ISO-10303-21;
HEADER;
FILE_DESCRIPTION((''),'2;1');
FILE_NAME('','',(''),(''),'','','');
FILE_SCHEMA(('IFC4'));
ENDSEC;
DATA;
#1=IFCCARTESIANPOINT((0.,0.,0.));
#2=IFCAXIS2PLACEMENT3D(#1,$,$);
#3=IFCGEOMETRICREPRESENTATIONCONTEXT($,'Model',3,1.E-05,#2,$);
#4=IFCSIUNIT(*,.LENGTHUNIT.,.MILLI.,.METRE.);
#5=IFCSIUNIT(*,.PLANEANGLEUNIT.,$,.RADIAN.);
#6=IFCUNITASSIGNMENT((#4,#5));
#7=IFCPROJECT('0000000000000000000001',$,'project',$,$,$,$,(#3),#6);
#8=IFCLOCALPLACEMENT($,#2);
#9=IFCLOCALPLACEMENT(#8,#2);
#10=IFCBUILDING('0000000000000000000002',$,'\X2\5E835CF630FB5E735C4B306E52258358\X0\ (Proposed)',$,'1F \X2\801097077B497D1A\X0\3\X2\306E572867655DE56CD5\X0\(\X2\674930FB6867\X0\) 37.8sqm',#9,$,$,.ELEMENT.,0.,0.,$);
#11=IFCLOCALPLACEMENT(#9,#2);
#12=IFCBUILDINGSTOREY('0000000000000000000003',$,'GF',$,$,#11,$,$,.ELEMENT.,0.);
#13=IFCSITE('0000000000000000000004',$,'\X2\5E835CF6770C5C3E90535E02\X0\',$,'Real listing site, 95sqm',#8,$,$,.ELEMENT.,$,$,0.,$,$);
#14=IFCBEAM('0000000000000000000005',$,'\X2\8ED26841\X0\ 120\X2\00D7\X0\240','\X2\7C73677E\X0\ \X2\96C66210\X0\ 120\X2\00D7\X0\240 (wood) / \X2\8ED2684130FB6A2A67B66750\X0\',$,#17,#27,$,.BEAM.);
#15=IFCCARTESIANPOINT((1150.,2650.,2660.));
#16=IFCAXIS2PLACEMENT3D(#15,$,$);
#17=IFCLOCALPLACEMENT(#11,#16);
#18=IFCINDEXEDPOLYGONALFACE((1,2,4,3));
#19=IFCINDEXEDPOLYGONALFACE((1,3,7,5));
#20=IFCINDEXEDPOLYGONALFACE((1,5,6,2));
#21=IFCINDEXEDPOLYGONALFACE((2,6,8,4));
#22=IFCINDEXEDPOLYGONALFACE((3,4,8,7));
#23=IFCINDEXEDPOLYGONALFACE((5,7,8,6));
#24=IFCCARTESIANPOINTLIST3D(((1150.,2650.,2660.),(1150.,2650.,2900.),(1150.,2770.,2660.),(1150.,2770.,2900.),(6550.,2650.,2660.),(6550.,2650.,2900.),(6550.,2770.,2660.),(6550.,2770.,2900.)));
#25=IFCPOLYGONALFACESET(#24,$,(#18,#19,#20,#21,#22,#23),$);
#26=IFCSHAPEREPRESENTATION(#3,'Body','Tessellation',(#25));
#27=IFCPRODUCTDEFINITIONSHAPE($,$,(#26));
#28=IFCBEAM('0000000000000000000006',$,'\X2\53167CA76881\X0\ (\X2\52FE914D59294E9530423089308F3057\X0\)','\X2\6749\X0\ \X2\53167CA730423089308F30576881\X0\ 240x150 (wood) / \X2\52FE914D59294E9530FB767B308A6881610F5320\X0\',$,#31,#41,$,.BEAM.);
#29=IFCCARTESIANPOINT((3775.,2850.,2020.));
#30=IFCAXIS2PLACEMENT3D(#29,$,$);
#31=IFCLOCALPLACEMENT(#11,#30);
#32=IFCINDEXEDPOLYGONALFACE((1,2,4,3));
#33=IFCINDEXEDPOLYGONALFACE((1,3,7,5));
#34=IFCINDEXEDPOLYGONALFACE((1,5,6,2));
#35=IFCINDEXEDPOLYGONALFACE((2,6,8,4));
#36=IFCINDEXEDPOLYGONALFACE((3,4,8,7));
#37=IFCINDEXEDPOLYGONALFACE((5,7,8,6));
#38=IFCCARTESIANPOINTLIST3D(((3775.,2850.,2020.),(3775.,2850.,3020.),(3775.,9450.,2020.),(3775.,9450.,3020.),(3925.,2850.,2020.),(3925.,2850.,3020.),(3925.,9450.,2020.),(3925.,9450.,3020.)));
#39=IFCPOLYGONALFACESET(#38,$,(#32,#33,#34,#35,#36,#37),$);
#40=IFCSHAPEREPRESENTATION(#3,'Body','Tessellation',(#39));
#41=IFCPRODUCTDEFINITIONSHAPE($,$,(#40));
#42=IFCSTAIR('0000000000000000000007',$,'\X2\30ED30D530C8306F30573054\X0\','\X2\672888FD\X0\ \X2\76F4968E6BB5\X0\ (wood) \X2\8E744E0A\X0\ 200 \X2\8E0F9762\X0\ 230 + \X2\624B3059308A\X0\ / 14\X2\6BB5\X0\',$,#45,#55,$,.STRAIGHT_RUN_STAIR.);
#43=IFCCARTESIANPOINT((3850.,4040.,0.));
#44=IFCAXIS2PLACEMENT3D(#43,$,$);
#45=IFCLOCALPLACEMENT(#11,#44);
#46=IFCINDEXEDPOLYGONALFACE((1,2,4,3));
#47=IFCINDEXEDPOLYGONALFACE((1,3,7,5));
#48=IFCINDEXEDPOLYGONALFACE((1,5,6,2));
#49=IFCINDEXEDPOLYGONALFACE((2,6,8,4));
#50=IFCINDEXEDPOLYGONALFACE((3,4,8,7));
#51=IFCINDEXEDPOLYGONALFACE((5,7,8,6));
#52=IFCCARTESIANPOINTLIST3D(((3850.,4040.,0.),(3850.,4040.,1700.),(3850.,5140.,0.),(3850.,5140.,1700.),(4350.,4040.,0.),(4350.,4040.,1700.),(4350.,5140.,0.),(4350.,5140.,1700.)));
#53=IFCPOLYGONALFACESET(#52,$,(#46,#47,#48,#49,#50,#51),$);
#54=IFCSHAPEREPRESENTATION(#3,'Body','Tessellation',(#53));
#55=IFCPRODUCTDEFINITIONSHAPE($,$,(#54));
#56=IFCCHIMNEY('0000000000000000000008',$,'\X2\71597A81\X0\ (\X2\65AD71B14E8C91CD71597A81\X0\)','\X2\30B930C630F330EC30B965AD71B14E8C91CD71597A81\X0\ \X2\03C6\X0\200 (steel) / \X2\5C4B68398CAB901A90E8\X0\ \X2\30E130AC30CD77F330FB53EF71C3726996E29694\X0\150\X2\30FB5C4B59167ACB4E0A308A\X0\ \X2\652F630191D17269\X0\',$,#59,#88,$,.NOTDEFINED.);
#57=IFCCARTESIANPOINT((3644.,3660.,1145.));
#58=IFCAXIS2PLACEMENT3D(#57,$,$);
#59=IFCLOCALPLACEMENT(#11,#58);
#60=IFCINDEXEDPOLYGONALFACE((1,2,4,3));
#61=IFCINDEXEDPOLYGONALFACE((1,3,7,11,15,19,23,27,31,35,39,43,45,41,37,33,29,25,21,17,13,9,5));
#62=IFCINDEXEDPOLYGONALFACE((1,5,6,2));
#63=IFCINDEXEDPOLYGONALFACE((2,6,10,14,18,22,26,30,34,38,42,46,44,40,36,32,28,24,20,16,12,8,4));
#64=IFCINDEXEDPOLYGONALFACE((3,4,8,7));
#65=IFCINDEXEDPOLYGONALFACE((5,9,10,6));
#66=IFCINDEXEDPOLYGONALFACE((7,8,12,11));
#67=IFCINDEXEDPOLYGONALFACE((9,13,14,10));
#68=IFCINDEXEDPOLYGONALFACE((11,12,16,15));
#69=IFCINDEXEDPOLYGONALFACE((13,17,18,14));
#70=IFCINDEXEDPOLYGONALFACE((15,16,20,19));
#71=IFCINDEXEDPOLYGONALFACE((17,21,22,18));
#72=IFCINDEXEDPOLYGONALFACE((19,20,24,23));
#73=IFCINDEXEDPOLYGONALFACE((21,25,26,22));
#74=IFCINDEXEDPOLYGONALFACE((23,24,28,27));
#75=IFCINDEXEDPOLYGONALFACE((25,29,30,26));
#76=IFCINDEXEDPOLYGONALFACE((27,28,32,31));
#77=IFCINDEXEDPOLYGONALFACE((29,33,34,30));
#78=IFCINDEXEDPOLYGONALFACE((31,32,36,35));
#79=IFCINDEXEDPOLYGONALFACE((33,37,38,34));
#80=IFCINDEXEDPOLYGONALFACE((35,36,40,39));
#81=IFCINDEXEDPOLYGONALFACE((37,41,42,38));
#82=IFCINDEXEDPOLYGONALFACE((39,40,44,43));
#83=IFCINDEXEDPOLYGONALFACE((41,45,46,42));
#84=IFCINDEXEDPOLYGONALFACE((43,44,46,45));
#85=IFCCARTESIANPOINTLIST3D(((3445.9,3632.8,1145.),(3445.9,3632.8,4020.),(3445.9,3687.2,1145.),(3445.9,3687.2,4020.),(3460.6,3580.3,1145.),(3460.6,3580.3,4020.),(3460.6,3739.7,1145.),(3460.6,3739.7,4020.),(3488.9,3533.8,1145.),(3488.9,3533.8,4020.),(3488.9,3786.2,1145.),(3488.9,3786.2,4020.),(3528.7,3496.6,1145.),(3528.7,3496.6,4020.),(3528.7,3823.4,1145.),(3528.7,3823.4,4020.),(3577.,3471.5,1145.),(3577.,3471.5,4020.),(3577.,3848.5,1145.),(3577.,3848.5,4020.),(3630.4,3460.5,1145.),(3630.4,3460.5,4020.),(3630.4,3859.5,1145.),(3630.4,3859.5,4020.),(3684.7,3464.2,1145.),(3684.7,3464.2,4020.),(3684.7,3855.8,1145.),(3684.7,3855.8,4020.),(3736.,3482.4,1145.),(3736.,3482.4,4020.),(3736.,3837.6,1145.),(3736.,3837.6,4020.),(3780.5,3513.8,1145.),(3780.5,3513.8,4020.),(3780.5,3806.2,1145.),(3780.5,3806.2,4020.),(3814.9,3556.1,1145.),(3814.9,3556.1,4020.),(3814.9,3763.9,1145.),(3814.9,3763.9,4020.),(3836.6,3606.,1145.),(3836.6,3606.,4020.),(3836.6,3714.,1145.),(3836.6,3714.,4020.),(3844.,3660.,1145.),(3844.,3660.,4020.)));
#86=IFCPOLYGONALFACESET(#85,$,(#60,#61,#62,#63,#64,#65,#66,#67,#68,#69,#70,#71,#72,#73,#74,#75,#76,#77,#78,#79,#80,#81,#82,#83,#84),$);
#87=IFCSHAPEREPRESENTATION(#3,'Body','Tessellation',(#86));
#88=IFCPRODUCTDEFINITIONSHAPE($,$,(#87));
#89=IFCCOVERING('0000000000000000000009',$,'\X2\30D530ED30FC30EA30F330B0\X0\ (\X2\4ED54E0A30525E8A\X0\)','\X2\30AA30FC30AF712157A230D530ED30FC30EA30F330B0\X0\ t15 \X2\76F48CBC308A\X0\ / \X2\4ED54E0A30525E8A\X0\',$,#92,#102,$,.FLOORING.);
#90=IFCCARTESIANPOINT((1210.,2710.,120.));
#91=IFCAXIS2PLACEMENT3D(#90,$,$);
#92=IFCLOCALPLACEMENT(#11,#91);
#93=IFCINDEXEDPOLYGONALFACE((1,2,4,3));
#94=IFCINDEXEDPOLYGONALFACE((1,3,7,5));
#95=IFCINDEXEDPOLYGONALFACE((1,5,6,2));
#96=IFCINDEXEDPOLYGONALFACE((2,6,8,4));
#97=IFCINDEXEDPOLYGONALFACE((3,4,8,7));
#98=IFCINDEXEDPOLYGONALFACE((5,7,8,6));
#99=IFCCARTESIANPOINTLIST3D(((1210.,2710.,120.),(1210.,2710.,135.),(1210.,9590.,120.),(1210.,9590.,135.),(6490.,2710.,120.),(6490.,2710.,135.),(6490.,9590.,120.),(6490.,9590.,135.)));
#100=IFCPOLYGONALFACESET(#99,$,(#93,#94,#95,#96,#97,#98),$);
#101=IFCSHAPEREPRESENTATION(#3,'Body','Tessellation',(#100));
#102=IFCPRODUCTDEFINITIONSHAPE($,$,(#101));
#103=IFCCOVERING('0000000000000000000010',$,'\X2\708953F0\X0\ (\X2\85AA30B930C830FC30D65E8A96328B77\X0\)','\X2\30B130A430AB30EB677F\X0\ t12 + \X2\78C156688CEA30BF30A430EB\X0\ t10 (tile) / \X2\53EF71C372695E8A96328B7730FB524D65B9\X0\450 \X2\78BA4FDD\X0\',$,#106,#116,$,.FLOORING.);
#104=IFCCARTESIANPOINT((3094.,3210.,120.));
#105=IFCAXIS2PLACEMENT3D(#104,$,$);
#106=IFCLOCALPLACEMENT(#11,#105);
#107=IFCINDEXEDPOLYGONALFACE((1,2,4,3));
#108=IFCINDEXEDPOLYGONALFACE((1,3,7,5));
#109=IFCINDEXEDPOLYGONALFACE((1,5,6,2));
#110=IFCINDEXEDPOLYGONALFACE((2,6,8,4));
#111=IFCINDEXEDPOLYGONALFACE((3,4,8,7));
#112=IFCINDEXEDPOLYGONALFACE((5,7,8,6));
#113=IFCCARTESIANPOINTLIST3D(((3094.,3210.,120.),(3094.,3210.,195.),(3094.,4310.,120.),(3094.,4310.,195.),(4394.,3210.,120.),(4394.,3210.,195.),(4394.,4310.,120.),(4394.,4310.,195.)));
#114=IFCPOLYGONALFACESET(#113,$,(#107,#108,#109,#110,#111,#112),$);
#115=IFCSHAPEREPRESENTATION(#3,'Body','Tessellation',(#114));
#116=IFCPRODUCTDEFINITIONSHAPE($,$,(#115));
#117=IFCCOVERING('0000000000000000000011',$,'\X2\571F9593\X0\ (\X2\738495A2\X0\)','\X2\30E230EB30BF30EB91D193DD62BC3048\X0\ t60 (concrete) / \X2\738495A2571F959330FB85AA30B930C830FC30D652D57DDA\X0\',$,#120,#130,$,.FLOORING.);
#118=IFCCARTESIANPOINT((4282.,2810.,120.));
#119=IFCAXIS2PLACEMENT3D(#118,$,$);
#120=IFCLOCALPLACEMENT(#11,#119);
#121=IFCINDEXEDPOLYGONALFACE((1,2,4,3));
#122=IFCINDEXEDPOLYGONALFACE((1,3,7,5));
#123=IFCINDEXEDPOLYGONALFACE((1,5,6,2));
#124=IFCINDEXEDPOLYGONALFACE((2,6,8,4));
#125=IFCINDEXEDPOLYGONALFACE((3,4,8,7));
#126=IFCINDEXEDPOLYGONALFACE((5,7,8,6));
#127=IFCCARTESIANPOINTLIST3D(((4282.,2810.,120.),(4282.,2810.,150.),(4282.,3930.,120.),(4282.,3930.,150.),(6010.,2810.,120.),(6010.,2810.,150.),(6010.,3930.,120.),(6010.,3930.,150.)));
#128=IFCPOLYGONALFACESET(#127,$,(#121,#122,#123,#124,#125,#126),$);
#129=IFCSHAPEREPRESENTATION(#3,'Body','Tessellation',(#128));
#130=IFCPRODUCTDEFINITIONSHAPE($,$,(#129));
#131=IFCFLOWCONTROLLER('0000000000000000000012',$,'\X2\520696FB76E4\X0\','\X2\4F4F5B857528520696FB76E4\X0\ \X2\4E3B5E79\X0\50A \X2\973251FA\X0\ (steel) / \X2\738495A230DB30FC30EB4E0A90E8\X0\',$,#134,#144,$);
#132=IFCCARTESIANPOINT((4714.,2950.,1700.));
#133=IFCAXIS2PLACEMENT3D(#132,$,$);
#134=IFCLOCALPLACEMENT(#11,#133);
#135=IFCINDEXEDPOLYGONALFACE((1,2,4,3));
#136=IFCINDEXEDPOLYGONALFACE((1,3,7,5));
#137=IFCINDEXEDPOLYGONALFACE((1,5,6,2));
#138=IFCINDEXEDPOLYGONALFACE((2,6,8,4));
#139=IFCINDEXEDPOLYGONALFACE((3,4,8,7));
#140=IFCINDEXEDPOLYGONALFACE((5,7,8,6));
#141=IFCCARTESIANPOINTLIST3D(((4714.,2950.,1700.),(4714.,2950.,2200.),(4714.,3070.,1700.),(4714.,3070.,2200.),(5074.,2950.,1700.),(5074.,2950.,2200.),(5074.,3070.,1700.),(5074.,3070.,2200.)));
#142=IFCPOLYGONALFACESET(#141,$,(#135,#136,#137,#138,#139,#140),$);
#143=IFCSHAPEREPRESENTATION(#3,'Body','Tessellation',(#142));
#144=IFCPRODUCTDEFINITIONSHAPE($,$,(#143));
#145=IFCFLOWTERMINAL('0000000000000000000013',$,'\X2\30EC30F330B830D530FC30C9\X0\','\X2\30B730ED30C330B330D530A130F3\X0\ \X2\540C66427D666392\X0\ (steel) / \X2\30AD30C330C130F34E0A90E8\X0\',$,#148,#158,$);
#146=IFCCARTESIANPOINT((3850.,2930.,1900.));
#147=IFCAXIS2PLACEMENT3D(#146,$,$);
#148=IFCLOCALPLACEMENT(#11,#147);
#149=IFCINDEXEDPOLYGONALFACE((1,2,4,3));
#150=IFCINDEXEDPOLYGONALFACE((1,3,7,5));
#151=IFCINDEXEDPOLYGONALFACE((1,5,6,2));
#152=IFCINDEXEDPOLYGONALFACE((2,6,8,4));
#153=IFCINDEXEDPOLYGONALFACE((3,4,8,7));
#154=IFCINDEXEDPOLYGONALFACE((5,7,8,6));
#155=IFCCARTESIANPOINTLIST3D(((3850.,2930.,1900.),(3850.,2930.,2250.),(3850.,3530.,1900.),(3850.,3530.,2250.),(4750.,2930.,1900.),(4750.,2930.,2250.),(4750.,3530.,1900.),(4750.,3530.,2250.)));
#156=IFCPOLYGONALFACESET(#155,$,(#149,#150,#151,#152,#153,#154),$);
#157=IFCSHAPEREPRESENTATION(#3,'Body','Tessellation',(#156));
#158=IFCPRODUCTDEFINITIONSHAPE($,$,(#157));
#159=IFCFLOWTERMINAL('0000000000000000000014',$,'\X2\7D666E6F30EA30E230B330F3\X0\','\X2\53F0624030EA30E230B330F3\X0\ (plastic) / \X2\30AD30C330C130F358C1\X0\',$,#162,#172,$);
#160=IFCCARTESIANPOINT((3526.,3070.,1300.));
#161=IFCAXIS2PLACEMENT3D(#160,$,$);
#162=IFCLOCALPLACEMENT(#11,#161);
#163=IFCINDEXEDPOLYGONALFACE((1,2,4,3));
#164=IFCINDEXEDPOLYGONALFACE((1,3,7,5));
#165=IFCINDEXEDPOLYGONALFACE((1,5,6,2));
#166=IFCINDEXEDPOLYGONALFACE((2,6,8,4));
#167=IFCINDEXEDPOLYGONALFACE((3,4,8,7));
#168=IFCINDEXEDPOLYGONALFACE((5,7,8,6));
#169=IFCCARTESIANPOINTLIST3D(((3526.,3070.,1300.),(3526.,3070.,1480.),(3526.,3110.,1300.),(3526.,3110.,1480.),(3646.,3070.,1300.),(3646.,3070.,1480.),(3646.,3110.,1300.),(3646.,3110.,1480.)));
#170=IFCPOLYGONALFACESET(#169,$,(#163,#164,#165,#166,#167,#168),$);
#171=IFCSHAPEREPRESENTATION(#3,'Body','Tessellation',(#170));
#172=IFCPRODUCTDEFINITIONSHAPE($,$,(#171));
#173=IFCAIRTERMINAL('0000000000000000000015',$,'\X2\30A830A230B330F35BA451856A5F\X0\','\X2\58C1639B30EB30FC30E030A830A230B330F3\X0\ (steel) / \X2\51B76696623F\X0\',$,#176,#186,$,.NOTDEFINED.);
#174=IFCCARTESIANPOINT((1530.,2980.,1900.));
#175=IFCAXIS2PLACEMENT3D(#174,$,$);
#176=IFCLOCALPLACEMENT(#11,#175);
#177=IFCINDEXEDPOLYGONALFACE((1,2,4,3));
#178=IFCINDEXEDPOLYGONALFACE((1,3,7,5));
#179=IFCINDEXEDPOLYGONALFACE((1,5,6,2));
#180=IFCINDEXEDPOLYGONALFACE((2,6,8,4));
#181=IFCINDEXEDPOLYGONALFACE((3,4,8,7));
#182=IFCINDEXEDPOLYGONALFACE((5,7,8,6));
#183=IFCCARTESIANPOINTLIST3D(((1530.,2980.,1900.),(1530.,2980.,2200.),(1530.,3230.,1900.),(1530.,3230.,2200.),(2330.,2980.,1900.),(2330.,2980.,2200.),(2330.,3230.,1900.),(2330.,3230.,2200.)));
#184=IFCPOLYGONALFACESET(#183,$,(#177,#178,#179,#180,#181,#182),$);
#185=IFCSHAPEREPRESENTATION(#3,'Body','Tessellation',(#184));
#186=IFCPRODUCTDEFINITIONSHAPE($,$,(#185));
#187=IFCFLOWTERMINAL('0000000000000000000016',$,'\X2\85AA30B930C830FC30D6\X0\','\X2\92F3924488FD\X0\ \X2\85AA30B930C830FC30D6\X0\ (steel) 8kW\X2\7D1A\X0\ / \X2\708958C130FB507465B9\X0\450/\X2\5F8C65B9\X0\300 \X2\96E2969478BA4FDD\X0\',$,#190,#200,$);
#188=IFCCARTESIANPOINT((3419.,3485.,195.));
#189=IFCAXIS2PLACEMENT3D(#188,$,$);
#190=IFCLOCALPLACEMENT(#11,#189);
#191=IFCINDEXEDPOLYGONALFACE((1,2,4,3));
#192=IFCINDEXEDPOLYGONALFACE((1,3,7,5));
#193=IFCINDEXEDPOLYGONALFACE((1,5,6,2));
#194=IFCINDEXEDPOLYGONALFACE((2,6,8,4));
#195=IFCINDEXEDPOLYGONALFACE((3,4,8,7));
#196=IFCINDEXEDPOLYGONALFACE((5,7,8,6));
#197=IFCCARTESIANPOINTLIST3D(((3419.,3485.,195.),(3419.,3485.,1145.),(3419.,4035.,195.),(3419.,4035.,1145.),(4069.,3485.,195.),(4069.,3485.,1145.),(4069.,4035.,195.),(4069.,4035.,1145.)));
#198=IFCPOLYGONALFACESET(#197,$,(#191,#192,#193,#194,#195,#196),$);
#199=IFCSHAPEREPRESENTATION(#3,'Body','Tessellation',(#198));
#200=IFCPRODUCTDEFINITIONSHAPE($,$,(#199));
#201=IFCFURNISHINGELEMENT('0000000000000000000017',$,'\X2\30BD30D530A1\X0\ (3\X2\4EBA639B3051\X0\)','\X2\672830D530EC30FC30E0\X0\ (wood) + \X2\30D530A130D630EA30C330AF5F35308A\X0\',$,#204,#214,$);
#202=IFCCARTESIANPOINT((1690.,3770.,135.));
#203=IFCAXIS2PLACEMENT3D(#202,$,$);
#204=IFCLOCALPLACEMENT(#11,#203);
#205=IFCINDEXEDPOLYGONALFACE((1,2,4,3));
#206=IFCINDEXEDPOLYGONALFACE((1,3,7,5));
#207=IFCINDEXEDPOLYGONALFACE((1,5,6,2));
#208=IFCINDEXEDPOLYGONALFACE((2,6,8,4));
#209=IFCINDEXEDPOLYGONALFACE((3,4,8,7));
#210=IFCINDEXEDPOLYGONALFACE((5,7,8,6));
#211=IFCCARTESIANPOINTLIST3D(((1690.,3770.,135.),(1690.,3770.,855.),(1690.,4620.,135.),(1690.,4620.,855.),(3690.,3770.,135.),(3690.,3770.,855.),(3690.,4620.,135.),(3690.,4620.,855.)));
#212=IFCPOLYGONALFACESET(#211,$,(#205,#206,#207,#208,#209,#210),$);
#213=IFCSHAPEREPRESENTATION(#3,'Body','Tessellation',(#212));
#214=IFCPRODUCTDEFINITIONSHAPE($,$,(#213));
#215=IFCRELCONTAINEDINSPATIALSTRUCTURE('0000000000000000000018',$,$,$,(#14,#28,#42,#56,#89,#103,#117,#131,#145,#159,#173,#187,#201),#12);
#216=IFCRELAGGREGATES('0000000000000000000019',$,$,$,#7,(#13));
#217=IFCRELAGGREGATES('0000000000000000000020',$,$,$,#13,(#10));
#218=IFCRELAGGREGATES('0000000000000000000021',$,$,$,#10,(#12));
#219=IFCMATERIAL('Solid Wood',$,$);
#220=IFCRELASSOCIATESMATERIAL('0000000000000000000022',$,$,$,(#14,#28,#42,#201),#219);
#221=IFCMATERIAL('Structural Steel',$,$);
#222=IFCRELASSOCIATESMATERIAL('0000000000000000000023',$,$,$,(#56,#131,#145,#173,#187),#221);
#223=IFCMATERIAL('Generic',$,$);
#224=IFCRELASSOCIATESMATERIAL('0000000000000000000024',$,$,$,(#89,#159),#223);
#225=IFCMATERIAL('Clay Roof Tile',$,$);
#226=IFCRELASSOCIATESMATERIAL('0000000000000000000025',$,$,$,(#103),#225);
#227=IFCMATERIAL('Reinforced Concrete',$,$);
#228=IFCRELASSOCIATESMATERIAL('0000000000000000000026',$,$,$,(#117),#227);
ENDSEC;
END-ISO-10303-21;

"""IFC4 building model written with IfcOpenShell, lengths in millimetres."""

from ifc_helpers import new_model, si_unit, frame, frame_2d, origin, origin_2d, place, context, project, spatial, rectangle, circle, extrude, material, element, save


model = new_model("IFC4")

# Units and contexts
model_context = context("Model", 3, precision=1e-05, world=origin())
ifc_project = project(units=[si_unit("LENGTHUNIT", "METRE", prefix="MILLI"), si_unit("PLANEANGLEUNIT", "RADIAN")], contexts=[model_context])

# Site, building, storey
site_placement = place(None, origin())
site = spatial("IfcSite", under=ifc_project, at=site_placement, Name="広島県尾道市", ObjectType="Real listing site, 95sqm", CompositionType="ELEMENT", RefElevation=0.0)
building_placement = place(site_placement, origin())
building = spatial("IfcBuilding", under=site, at=building_placement, Name="広島・平屋の別荘 (Proposed)", ObjectType="1F 耐震等級3の在来工法(杉・桧) 37.8sqm", CompositionType="ELEMENT", ElevationOfRefHeight=0.0, ElevationOfTerrain=0.0)
storey_placement = place(building_placement, origin())
storey = spatial("IfcBuildingStorey", under=building, at=storey_placement, Name="GF", CompositionType="ELEMENT", Elevation=0.0)

# Beams
ifc_material_1 = material(Name="Solid Wood")
beam_1_placement = place(storey_placement, frame((1150.0, 2650.0, 2660.0)))
element("IfcBeam", 1, at=beam_1_placement, inside=storey, material=ifc_material_1, Name="軒桁 120×240", Description="米松 集成 120×240 (wood) / 軒桁・横架材", PredefinedType="BEAM", context=model_context, shape_type="SweptSolid", body=[
    extrude(rectangle(XDim=5400.0, YDim=120.0, at=frame_2d((2700.0, 60.0))), frame((1150.0, 2650.0, 2660.0)), (0.0, 0.0, 1.0), 240.0),
])
beam_2_placement = place(storey_placement, frame((3775.0, 2850.0, 2020.0)))
element("IfcBeam", 2, at=beam_2_placement, inside=storey, material=ifc_material_1, Name="化粧梁 (勾配天井あらわし)", Description="杉 化粧あらわし梁 240x150 (wood) / 勾配天井・登り梁意匠", PredefinedType="BEAM", context=model_context, shape_type="SweptSolid", body=[
    extrude(rectangle(XDim=150.0, YDim=6600.0, at=frame_2d((75.0, 3300.0))), frame((3775.0, 2850.0, 2020.0)), (0.0, 0.0, 1.0), 1000.0),
])

# Stair
stair_placement = place(storey_placement, frame((3850.0, 4040.0, 0.0)))
element("IfcStair", 3, at=stair_placement, inside=storey, material=ifc_material_1, Name="ロフトはしご", Description="木製 直階段 (wood) 蹴上 200 踏面 230 + 手すり / 14段", PredefinedType="STRAIGHT_RUN_STAIR", context=model_context, shape_type="SweptSolid", body=[
    extrude(rectangle(XDim=500.0, YDim=1100.0, at=frame_2d((250.0, 550.0))), frame((3850.0, 4040.0, 0.0)), (0.0, 0.0, 1.0), 1700.0),
])

# Chimney
ifc_material_2 = material(Name="Structural Steel")
chimney_placement = place(storey_placement, frame((3644.0, 3660.0, 1145.0)))
element("IfcChimney", 4, at=chimney_placement, inside=storey, material=ifc_material_2, Name="煙突 (断熱二重煙突)", Description="ステンレス断熱二重煙突 φ200 (steel) / 屋根貫通部 メガネ石・可燃物離隔150・屋外立上り 支持金物", PredefinedType="NOTDEFINED", context=model_context, shape_type="SweptSolid", body=[
    extrude(circle(Radius=200.0, at=origin_2d()), frame((3644.0, 3660.0, 1145.0)), (0.0, 0.0, 1.0), 2875.0),
])

# Coverings
ifc_material_3 = material(Name="Generic")
covering_1_placement = place(storey_placement, frame((1210.0, 2710.0, 120.0)))
element("IfcCovering", 5, at=covering_1_placement, inside=storey, material=ifc_material_3, Name="フローリング (仕上げ床)", Description="オーク無垢フローリング t15 直貼り / 仕上げ床", PredefinedType="FLOORING", context=model_context, shape_type="SweptSolid", body=[
    extrude(rectangle(XDim=5280.0, YDim=6880.0, at=frame_2d((2640.0, 3440.0))), frame((1210.0, 2710.0, 120.0)), (0.0, 0.0, 1.0), 15.0),
])
ifc_material_4 = material(Name="Clay Roof Tile")
covering_2_placement = place(storey_placement, frame((3094.0, 3210.0, 120.0)))
element("IfcCovering", 6, at=covering_2_placement, inside=storey, material=ifc_material_4, Name="炉台 (薪ストーブ床防護)", Description="ケイカル板 t12 + 磁器質タイル t10 (tile) / 可燃物床防護・前方450 確保", PredefinedType="FLOORING", context=model_context, shape_type="SweptSolid", body=[
    extrude(rectangle(XDim=1300.0, YDim=1100.0, at=frame_2d((650.0, 550.0))), frame((3094.0, 3210.0, 120.0)), (0.0, 0.0, 1.0), 75.0),
])
ifc_material_5 = material(Name="Reinforced Concrete")
covering_3_placement = place(storey_placement, frame((4282.0, 2810.0, 120.0)))
element("IfcCovering", 7, at=covering_3_placement, inside=storey, material=ifc_material_5, Name="土間 (玄関)", Description="モルタル金鏝押え t60 (concrete) / 玄関土間・薪ストーブ動線", PredefinedType="FLOORING", context=model_context, shape_type="SweptSolid", body=[
    extrude(rectangle(XDim=1728.0, YDim=1120.0, at=frame_2d((864.0, 560.0))), frame((4282.0, 2810.0, 120.0)), (0.0, 0.0, 1.0), 30.0),
])

# Flow controller
flow_controller_placement = place(storey_placement, frame((4714.0, 2950.0, 1700.0)))
element("IfcFlowController", 8, at=flow_controller_placement, inside=storey, material=ifc_material_2, Name="分電盤", Description="住宅用分電盤 主幹50A 露出 (steel) / 玄関ホール上部", context=model_context, shape_type="SweptSolid", body=[
    extrude(rectangle(XDim=360.0, YDim=120.0, at=frame_2d((180.0, 60.0))), frame((4714.0, 2950.0, 1700.0)), (0.0, 0.0, 1.0), 500.0),
])

# Flow terminals
flow_terminal_1_placement = place(storey_placement, frame((3850.0, 2930.0, 1900.0)))
element("IfcFlowTerminal", 9, at=flow_terminal_1_placement, inside=storey, material=ifc_material_2, Name="レンジフード", Description="シロッコファン 同時給排 (steel) / キッチン上部", context=model_context, shape_type="SweptSolid", body=[
    extrude(rectangle(XDim=900.0, YDim=600.0, at=frame_2d((450.0, 300.0))), frame((3850.0, 2930.0, 1900.0)), (0.0, 0.0, 1.0), 350.0),
])
flow_terminal_2_placement = place(storey_placement, frame((3526.0, 3070.0, 1300.0)))
element("IfcFlowTerminal", 10, at=flow_terminal_2_placement, inside=storey, material=ifc_material_3, Name="給湯リモコン", Description="台所リモコン (plastic) / キッチン壁", context=model_context, shape_type="SweptSolid", body=[
    extrude(rectangle(XDim=120.0, YDim=40.0, at=frame_2d((60.0, 20.0))), frame((3526.0, 3070.0, 1300.0)), (0.0, 0.0, 1.0), 180.0),
])

# Air terminal
air_terminal_placement = place(storey_placement, frame((1530.0, 2980.0, 1900.0)))
element("IfcAirTerminal", 11, at=air_terminal_placement, inside=storey, material=ifc_material_2, Name="エアコン室内機", Description="壁掛ルームエアコン (steel) / 冷暖房", PredefinedType="NOTDEFINED", context=model_context, shape_type="SweptSolid", body=[
    extrude(rectangle(XDim=800.0, YDim=250.0, at=frame_2d((400.0, 125.0))), frame((1530.0, 2980.0, 1900.0)), (0.0, 0.0, 1.0), 300.0),
])

# Flow terminal
flow_terminal_3_placement = place(storey_placement, frame((3419.0, 3485.0, 195.0)))
element("IfcFlowTerminal", 12, at=flow_terminal_3_placement, inside=storey, material=ifc_material_2, Name="薪ストーブ", Description="鋳鉄製 薪ストーブ (steel) 8kW級 / 炉壁・側方450/後方300 離隔確保", context=model_context, shape_type="SweptSolid", body=[
    extrude(rectangle(XDim=650.0, YDim=550.0, at=frame_2d((325.0, 275.0))), frame((3419.0, 3485.0, 195.0)), (0.0, 0.0, 1.0), 950.0),
])

# Furnishing element
furnishing_1_placement = place(storey_placement, frame((1690.0, 3770.0, 135.0)))
element("IfcFurnishingElement", 13, at=furnishing_1_placement, inside=storey, material=ifc_material_1, Name="ソファ (3人掛け)", Description="木フレーム (wood) + ファブリック張り", context=model_context, shape_type="SweptSolid", body=[
    extrude(rectangle(XDim=2000.0, YDim=850.0, at=frame_2d((1000.0, 425.0))), frame((1690.0, 3770.0, 135.0)), (0.0, 0.0, 1.0), 720.0),
])

save(model, "model.ifc")
